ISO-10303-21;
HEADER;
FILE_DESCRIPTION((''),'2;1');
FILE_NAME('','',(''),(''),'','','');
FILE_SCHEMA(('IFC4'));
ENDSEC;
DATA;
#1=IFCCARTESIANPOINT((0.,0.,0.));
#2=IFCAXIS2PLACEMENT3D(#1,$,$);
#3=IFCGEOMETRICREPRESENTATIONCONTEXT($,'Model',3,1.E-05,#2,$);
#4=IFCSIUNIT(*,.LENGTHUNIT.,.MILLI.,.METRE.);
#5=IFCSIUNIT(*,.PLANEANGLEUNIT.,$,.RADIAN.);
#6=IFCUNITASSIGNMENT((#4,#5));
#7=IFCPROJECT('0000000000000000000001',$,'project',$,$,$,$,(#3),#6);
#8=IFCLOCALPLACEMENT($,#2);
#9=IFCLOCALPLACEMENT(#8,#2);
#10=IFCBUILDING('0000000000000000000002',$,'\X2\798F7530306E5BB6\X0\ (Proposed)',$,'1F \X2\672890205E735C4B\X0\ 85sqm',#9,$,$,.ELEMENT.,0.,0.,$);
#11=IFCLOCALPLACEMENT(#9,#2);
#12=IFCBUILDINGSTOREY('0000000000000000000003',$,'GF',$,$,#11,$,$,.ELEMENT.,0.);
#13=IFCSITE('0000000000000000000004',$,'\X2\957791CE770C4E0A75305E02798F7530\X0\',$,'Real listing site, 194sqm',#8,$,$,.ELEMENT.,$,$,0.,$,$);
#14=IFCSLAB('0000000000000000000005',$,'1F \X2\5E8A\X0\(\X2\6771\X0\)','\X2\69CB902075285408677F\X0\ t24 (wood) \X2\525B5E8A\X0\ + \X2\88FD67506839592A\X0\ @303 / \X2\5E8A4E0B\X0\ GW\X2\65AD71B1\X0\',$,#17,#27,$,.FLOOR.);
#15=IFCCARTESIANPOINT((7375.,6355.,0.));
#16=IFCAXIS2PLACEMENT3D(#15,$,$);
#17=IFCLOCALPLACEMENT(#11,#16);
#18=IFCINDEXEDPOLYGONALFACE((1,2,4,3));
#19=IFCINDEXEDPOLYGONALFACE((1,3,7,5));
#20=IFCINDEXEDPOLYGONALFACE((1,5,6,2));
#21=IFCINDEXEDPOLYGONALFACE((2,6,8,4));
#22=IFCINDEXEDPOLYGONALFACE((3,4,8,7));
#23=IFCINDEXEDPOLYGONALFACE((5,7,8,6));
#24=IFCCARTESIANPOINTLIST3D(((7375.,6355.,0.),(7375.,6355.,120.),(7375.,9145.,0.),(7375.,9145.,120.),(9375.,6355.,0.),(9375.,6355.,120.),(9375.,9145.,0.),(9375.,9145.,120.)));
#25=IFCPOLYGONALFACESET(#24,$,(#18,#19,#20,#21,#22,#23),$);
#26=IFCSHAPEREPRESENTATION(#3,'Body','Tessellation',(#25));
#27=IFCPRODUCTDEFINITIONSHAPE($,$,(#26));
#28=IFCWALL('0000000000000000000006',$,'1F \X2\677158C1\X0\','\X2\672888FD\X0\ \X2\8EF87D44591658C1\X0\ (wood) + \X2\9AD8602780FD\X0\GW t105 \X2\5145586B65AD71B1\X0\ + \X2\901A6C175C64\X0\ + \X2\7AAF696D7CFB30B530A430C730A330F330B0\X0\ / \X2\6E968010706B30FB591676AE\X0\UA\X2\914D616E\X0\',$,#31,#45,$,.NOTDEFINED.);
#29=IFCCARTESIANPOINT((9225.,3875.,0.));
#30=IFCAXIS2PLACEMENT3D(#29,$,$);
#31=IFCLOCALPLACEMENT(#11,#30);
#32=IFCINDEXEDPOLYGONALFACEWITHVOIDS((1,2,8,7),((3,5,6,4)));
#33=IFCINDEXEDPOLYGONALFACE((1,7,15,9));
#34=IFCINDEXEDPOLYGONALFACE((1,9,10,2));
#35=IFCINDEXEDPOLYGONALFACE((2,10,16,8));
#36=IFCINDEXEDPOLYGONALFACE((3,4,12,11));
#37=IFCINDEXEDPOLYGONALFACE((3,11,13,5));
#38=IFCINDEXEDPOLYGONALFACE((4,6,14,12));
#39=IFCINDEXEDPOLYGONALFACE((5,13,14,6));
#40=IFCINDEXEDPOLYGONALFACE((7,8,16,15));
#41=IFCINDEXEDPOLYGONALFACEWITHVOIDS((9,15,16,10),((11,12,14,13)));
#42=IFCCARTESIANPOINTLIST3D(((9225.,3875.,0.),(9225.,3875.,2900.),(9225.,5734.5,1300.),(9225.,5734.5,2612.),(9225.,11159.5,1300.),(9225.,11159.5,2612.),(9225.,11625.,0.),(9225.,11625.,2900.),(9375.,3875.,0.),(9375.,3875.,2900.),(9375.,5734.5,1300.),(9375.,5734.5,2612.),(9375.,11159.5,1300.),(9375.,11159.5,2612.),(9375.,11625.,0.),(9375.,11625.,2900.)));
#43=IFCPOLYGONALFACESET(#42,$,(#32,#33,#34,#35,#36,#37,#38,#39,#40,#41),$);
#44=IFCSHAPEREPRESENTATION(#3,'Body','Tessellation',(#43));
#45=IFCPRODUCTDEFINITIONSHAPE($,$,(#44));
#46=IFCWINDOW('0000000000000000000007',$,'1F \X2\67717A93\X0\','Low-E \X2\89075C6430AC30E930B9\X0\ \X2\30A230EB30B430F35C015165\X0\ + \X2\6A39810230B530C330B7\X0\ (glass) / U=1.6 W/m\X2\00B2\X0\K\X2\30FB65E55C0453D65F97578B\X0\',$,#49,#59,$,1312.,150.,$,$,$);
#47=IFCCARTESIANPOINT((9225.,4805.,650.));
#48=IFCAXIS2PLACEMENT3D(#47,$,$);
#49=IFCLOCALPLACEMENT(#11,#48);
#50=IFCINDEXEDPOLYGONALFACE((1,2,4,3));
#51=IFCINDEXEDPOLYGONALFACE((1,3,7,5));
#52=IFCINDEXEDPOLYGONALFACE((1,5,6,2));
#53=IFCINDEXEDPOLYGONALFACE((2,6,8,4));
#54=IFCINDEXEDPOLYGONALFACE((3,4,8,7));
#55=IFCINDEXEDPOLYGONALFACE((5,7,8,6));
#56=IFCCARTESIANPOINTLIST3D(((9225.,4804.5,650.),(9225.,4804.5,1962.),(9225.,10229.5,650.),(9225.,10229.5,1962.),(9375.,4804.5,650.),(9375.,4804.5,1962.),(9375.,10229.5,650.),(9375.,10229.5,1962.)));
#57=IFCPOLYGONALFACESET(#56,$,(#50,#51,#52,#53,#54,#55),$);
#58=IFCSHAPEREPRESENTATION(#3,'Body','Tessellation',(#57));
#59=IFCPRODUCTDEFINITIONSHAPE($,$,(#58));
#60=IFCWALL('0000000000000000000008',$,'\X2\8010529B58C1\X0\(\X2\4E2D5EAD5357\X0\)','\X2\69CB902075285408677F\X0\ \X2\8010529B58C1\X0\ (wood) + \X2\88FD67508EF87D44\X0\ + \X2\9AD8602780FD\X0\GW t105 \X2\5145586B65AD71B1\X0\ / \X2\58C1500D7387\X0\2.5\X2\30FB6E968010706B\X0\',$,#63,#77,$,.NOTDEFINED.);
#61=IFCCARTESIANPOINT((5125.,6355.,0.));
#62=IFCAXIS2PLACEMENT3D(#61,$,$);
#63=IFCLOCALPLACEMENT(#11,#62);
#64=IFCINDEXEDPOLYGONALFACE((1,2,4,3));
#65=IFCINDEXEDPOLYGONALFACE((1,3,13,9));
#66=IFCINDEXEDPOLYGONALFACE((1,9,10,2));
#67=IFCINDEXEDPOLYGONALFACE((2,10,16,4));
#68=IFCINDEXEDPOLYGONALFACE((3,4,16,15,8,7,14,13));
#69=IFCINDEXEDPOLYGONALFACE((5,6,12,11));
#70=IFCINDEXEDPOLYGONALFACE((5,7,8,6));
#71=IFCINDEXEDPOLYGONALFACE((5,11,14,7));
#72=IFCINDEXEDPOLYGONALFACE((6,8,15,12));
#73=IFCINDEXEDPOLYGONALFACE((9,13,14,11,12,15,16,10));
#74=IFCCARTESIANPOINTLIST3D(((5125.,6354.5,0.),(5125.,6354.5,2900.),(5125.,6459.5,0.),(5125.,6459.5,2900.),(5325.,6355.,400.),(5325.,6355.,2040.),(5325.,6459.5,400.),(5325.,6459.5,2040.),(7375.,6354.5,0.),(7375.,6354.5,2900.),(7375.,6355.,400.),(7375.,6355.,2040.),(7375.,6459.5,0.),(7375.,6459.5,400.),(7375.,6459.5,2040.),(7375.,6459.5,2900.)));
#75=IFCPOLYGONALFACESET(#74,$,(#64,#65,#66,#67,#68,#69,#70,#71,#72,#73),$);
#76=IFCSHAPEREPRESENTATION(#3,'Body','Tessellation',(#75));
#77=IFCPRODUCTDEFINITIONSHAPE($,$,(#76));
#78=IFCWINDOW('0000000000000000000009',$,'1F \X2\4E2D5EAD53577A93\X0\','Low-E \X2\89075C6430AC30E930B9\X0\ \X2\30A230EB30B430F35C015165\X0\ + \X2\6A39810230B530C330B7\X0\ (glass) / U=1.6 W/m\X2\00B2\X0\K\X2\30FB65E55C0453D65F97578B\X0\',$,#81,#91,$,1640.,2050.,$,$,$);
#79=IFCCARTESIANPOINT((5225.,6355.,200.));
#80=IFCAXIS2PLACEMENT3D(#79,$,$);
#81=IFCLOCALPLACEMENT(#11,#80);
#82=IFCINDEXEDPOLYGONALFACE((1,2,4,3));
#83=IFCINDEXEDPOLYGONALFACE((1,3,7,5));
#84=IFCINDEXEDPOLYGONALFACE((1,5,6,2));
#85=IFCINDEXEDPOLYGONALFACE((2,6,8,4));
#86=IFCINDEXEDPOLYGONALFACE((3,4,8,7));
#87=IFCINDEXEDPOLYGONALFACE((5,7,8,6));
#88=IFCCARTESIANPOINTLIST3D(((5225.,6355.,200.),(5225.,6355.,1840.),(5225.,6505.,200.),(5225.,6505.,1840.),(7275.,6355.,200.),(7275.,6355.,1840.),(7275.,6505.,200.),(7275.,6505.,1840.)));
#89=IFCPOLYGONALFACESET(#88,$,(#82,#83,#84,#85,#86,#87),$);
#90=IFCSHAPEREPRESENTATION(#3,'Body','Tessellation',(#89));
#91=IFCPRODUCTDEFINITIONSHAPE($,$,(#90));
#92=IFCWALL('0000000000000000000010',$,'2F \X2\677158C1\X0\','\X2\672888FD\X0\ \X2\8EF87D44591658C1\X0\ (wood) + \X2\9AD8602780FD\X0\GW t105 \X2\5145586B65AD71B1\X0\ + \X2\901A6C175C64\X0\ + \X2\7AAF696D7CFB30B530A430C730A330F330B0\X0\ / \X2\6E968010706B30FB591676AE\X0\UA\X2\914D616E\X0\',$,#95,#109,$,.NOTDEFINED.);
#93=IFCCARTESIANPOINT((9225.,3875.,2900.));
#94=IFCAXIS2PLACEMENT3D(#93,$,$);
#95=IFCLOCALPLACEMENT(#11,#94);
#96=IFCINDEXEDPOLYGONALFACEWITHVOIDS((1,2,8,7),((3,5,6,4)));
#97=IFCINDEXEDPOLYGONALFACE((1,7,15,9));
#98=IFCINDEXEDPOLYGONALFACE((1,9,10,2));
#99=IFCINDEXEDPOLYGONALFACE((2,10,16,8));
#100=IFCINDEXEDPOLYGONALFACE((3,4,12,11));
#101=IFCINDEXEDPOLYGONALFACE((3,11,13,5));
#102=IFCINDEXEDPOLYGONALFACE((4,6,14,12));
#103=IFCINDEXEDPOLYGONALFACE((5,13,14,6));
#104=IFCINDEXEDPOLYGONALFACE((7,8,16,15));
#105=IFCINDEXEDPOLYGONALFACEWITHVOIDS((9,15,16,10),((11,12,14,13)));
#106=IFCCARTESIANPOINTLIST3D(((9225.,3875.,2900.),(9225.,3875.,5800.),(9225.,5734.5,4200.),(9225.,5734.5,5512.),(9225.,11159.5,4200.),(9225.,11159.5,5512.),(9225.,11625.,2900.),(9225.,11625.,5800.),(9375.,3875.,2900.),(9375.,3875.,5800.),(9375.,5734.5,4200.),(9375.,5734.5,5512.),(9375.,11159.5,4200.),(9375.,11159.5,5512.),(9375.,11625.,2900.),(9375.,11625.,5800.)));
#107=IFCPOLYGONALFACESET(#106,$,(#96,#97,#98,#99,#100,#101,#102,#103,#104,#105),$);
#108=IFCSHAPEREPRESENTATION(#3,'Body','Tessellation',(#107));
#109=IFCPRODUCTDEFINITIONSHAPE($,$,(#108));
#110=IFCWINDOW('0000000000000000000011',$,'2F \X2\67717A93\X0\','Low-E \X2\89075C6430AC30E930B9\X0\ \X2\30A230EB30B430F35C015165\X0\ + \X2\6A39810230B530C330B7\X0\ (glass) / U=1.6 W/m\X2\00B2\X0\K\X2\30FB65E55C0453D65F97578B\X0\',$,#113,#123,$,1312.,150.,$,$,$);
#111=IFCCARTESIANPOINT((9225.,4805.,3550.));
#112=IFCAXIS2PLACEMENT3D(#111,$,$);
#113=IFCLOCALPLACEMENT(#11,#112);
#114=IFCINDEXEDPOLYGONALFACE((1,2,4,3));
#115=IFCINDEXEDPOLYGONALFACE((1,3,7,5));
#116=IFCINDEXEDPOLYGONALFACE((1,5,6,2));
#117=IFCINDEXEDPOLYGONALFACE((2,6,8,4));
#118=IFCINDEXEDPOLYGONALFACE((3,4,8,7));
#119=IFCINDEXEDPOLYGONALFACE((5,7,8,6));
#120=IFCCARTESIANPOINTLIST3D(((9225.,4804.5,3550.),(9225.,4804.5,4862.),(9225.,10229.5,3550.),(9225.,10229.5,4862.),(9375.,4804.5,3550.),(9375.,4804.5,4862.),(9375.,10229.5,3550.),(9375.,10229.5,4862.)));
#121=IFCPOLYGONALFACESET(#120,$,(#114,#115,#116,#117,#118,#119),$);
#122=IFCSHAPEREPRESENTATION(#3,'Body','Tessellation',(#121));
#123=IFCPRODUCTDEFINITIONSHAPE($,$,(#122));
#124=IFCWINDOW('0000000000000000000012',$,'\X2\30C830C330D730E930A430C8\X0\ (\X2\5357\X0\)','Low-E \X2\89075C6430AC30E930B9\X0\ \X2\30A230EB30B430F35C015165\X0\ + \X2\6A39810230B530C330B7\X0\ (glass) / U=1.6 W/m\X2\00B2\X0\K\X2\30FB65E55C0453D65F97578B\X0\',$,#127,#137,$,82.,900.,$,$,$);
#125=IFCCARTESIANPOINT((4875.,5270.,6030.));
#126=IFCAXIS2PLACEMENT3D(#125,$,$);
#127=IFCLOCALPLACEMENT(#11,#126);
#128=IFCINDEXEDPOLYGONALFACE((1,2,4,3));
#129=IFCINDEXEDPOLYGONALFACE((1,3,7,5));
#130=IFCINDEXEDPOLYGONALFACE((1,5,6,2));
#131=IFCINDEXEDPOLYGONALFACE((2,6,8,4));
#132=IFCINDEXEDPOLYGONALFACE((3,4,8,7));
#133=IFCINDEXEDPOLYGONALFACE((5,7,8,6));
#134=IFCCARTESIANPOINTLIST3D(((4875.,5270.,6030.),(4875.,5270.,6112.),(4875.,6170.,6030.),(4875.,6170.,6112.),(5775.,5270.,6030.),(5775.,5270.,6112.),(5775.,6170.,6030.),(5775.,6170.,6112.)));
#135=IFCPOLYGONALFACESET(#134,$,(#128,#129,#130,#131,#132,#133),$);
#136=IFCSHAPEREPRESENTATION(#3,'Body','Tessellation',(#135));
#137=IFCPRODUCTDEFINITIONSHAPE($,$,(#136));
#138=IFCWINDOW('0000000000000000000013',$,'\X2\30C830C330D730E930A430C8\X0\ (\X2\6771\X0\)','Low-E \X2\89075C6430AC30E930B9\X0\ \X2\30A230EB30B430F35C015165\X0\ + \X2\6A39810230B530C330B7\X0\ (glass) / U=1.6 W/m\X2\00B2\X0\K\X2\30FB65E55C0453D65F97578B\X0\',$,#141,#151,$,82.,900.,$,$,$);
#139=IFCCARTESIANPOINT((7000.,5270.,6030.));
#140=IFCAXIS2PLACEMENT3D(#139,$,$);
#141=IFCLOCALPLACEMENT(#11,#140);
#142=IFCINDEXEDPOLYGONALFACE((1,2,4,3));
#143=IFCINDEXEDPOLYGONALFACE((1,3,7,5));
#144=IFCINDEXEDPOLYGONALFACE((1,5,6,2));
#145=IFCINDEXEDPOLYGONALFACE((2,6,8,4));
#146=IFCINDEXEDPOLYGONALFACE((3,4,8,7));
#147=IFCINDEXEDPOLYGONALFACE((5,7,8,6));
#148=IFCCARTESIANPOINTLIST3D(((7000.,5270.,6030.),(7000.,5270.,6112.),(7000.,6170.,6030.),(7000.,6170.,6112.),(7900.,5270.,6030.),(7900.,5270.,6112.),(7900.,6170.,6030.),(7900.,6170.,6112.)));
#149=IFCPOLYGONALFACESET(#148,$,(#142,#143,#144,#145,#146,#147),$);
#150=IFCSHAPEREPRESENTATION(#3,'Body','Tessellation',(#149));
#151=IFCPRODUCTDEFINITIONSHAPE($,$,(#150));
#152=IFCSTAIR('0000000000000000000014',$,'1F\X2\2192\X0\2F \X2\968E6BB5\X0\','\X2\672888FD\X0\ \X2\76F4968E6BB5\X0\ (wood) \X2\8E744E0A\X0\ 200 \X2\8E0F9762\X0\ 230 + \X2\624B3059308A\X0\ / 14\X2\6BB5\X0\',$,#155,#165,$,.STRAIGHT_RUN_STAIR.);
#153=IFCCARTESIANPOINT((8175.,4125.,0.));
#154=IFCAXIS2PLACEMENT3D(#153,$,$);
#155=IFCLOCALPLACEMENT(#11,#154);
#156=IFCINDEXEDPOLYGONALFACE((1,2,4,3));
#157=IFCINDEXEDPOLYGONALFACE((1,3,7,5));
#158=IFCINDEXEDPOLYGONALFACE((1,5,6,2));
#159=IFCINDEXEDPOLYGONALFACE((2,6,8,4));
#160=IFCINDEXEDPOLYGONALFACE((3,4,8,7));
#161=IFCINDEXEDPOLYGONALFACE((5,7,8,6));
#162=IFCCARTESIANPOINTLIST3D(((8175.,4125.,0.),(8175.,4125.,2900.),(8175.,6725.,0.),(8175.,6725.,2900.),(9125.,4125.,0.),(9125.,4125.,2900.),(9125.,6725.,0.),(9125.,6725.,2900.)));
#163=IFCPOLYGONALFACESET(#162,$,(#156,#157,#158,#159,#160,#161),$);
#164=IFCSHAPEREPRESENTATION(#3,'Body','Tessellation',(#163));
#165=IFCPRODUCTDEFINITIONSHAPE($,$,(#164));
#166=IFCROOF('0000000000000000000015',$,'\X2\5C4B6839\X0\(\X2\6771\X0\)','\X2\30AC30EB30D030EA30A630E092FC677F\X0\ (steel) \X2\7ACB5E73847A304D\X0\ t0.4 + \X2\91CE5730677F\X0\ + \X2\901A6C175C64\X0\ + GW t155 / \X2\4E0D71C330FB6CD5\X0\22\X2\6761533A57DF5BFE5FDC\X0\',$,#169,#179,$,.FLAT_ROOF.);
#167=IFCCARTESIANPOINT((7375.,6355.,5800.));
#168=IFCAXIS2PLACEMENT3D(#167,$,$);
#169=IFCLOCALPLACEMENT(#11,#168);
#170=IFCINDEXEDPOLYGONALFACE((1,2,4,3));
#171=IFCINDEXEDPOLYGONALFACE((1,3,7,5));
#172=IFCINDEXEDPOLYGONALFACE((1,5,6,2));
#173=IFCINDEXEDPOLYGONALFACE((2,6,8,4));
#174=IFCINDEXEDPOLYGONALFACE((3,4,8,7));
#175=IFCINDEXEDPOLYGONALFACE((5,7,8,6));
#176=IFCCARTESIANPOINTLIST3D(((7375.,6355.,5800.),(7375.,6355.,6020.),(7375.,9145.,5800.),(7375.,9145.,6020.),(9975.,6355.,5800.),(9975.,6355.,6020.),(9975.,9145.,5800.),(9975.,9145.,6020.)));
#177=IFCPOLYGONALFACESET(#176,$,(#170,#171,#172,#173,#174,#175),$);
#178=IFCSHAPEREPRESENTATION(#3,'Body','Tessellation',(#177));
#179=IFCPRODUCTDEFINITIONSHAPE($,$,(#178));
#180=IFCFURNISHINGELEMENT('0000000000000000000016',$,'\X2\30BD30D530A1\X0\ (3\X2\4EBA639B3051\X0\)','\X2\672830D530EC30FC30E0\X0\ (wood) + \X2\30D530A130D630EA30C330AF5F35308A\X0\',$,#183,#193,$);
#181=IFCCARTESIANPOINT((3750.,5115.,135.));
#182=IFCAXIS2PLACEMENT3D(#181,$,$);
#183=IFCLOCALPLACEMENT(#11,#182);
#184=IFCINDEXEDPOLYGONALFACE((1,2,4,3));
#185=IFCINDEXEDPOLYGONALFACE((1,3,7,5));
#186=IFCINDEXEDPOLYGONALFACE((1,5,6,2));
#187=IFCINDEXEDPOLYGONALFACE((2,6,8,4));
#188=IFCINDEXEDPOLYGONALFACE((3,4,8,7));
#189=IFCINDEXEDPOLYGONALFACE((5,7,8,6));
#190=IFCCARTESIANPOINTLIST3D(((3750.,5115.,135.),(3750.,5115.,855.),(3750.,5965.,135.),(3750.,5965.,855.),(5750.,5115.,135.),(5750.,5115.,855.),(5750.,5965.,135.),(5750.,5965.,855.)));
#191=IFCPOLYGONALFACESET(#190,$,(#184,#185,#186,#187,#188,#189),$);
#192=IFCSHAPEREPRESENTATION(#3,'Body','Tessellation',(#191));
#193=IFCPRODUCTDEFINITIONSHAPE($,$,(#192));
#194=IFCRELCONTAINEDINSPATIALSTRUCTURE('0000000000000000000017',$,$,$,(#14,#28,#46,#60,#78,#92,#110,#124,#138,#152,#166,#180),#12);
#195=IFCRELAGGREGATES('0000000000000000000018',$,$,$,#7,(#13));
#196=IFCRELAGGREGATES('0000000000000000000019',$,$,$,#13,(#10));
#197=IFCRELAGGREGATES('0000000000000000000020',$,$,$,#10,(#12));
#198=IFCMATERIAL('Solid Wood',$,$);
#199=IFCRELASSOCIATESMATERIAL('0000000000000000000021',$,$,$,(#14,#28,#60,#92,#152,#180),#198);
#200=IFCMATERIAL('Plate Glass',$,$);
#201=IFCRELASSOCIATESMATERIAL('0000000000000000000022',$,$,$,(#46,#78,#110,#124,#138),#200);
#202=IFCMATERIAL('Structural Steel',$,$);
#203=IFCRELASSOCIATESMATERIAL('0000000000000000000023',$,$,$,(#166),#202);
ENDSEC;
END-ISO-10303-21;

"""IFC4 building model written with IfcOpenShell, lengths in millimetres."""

from ifc_helpers import new_model, si_unit, frame, frame_2d, origin, place, context, project, spatial, rectangle, extrude, material, element, fill, save


model = new_model("IFC4")

# Units and contexts
model_context = context("Model", 3, precision=1e-05, world=origin())
ifc_project = project(units=[si_unit("LENGTHUNIT", "METRE", prefix="MILLI"), si_unit("PLANEANGLEUNIT", "RADIAN")], contexts=[model_context])

# Site, building, storey
site_placement = place(None, origin())
site = spatial("IfcSite", under=ifc_project, at=site_placement, Name="長野県上田市福田", ObjectType="Real listing site, 194sqm", CompositionType="ELEMENT", RefElevation=0.0)
building_placement = place(site_placement, origin())
building = spatial("IfcBuilding", under=site, at=building_placement, Name="福田の家 (Proposed)", ObjectType="1F 木造平屋 85sqm", CompositionType="ELEMENT", ElevationOfRefHeight=0.0, ElevationOfTerrain=0.0)
storey_placement = place(building_placement, origin())
storey = spatial("IfcBuildingStorey", under=building, at=storey_placement, Name="GF", CompositionType="ELEMENT", Elevation=0.0)

# Slab
ifc_material_1 = material(Name="Solid Wood")
slab_placement = place(storey_placement, frame((7375.0, 6355.0, 0.0)))
element("IfcSlab", 1, at=slab_placement, inside=storey, material=ifc_material_1, Name="1F 床(東)", Description="構造用合板 t24 (wood) 剛床 + 製材根太 @303 / 床下 GW断熱", PredefinedType="FLOOR", context=model_context, shape_type="SweptSolid", body=[
    extrude(rectangle(XDim=2000.0, YDim=2790.0, at=frame_2d((1000.0, 1395.0))), frame((7375.0, 6355.0, 0.0)), (0.0, 0.0, 1.0), 120.0),
])

# Walls, openings, windows
wall_1_placement = place(storey_placement, frame((9225.0, 3875.0, 0.0)))
wall_1 = element("IfcWall", 2, at=wall_1_placement, inside=storey, material=ifc_material_1, Name="1F 東壁", Description="木製 軸組外壁 (wood) + 高性能GW t105 充填断熱 + 通気層 + 窯業系サイディング / 準耐火・外皮UA配慮", PredefinedType="NOTDEFINED", context=model_context, shape_type="SweptSolid", body=[
    extrude(rectangle(XDim=150.0, YDim=7750.0, at=frame_2d((75.0, 3875.0))), frame((9225.0, 3875.0, 0.0)), (0.0, 0.0, 1.0), 2900.0),
])
opening_1_placement = place(storey_placement, frame((9225.0, 4805.0, 650.0)))
opening_1 = element("IfcOpeningElement", 3, at=opening_1_placement, cuts=wall_1, PredefinedType="NOTDEFINED", context=model_context, shape_type="SweptSolid", body=[
    extrude(rectangle(XDim=150.0, YDim=5425.0, at=frame_2d((75.0, 2712.0))), frame((9225.0, 4805.0, 650.0)), (0.0, 0.0, 1.0), 1312.0),
])
ifc_material_2 = material(Name="Plate Glass")
window_1_placement = place(storey_placement, frame((9225.0, 4805.0, 650.0)))
window_1 = element("IfcWindow", 4, at=window_1_placement, inside=storey, material=ifc_material_2, Name="1F 東窓", Description="Low-E 複層ガラス アルゴン封入 + 樹脂サッシ (glass) / U=1.6 W/m²K・日射取得型", OverallHeight=1312.0, OverallWidth=150.0, context=model_context, shape_type="SweptSolid", body=[
    extrude(rectangle(XDim=150.0, YDim=5425.0, at=frame_2d((75.0, 2712.0))), frame((9225.0, 4805.0, 650.0)), (0.0, 0.0, 1.0), 1312.0),
])
fill(opening_1, window_1)
wall_2_placement = place(storey_placement, frame((5125.0, 6355.0, 0.0)))
wall_2 = element("IfcWall", 5, at=wall_2_placement, inside=storey, material=ifc_material_1, Name="耐力壁(中庭南)", Description="構造用合板 耐力壁 (wood) + 製材軸組 + 高性能GW t105 充填断熱 / 壁倍率2.5・準耐火", PredefinedType="NOTDEFINED", context=model_context, shape_type="SweptSolid", body=[
    extrude(rectangle(XDim=2250.0, YDim=105.0, at=frame_2d((1125.0, 52.0))), frame((5125.0, 6355.0, 0.0)), (0.0, 0.0, 1.0), 2900.0),
])
opening_2_placement = place(storey_placement, frame((5225.0, 6355.0, 200.0)))
opening_2 = element("IfcOpeningElement", 6, at=opening_2_placement, cuts=wall_2, PredefinedType="NOTDEFINED", context=model_context, shape_type="SweptSolid", body=[
    extrude(rectangle(XDim=2050.0, YDim=150.0, at=frame_2d((1025.0, 75.0))), frame((5225.0, 6355.0, 200.0)), (0.0, 0.0, 1.0), 1640.0),
])
window_2_placement = place(storey_placement, frame((5225.0, 6355.0, 200.0)))
window_2 = element("IfcWindow", 7, at=window_2_placement, inside=storey, material=ifc_material_2, Name="1F 中庭南窓", Description="Low-E 複層ガラス アルゴン封入 + 樹脂サッシ (glass) / U=1.6 W/m²K・日射取得型", OverallHeight=1640.0, OverallWidth=2050.0, context=model_context, shape_type="SweptSolid", body=[
    extrude(rectangle(XDim=2050.0, YDim=150.0, at=frame_2d((1025.0, 75.0))), frame((5225.0, 6355.0, 200.0)), (0.0, 0.0, 1.0), 1640.0),
])
fill(opening_2, window_2)

# Wall, opening, window
wall_3_placement = place(storey_placement, frame((9225.0, 3875.0, 2900.0)))
wall_3 = element("IfcWall", 8, at=wall_3_placement, inside=storey, material=ifc_material_1, Name="2F 東壁", Description="木製 軸組外壁 (wood) + 高性能GW t105 充填断熱 + 通気層 + 窯業系サイディング / 準耐火・外皮UA配慮", PredefinedType="NOTDEFINED", context=model_context, shape_type="SweptSolid", body=[
    extrude(rectangle(XDim=150.0, YDim=7750.0, at=frame_2d((75.0, 3875.0))), frame((9225.0, 3875.0, 2900.0)), (0.0, 0.0, 1.0), 2900.0),
])
opening_3_placement = place(storey_placement, frame((9225.0, 4805.0, 3550.0)))
opening_3 = element("IfcOpeningElement", 9, at=opening_3_placement, cuts=wall_3, PredefinedType="NOTDEFINED", context=model_context, shape_type="SweptSolid", body=[
    extrude(rectangle(XDim=150.0, YDim=5425.0, at=frame_2d((75.0, 2712.0))), frame((9225.0, 4805.0, 3550.0)), (0.0, 0.0, 1.0), 1312.0),
])
window_3_placement = place(storey_placement, frame((9225.0, 4805.0, 3550.0)))
window_3 = element("IfcWindow", 10, at=window_3_placement, inside=storey, material=ifc_material_2, Name="2F 東窓", Description="Low-E 複層ガラス アルゴン封入 + 樹脂サッシ (glass) / U=1.6 W/m²K・日射取得型", OverallHeight=1312.0, OverallWidth=150.0, context=model_context, shape_type="SweptSolid", body=[
    extrude(rectangle(XDim=150.0, YDim=5425.0, at=frame_2d((75.0, 2712.0))), frame((9225.0, 4805.0, 3550.0)), (0.0, 0.0, 1.0), 1312.0),
])
fill(opening_3, window_3)

# Windows
window_4_placement = place(storey_placement, frame((4875.0, 5270.0, 6030.0)))
element("IfcWindow", 11, at=window_4_placement, inside=storey, material=ifc_material_2, Name="トップライト (南)", Description="Low-E 複層ガラス アルゴン封入 + 樹脂サッシ (glass) / U=1.6 W/m²K・日射取得型", OverallHeight=82.0, OverallWidth=900.0, context=model_context, shape_type="SweptSolid", body=[
    extrude(rectangle(XDim=900.0, YDim=900.0, at=frame_2d((450.0, 450.0))), frame((4875.0, 5270.0, 6030.0)), (0.0, 0.0, 1.0), 82.0),
])
window_5_placement = place(storey_placement, frame((7000.0, 5270.0, 6030.0)))
element("IfcWindow", 12, at=window_5_placement, inside=storey, material=ifc_material_2, Name="トップライト (東)", Description="Low-E 複層ガラス アルゴン封入 + 樹脂サッシ (glass) / U=1.6 W/m²K・日射取得型", OverallHeight=82.0, OverallWidth=900.0, context=model_context, shape_type="SweptSolid", body=[
    extrude(rectangle(XDim=900.0, YDim=900.0, at=frame_2d((450.0, 450.0))), frame((7000.0, 5270.0, 6030.0)), (0.0, 0.0, 1.0), 82.0),
])

# Stair
stair_placement = place(storey_placement, frame((8175.0, 4125.0, 0.0)))
element("IfcStair", 13, at=stair_placement, inside=storey, material=ifc_material_1, Name="1F→2F 階段", Description="木製 直階段 (wood) 蹴上 200 踏面 230 + 手すり / 14段", PredefinedType="STRAIGHT_RUN_STAIR", context=model_context, shape_type="SweptSolid", body=[
    extrude(rectangle(XDim=950.0, YDim=2600.0, at=frame_2d((475.0, 1300.0))), frame((8175.0, 4125.0, 0.0)), (0.0, 0.0, 1.0), 2900.0),
])

# Roof
ifc_material_3 = material(Name="Structural Steel")
roof_placement = place(storey_placement, frame((7375.0, 6355.0, 5800.0)))
element("IfcRoof", 14, at=roof_placement, inside=storey, material=ifc_material_3, Name="屋根(東)", Description="ガルバリウム鋼板 (steel) 立平葺き t0.4 + 野地板 + 通気層 + GW t155 / 不燃・法22条区域対応", PredefinedType="FLAT_ROOF", context=model_context, shape_type="SweptSolid", body=[
    extrude(rectangle(XDim=2600.0, YDim=2790.0, at=frame_2d((1300.0, 1395.0))), frame((7375.0, 6355.0, 5800.0)), (0.0, 0.0, 1.0), 220.0),
])

# Furnishing element
furnishing_1_placement = place(storey_placement, frame((3750.0, 5115.0, 135.0)))
element("IfcFurnishingElement", 15, at=furnishing_1_placement, inside=storey, material=ifc_material_1, Name="ソファ (3人掛け)", Description="木フレーム (wood) + ファブリック張り", context=model_context, shape_type="SweptSolid", body=[
    extrude(rectangle(XDim=2000.0, YDim=850.0, at=frame_2d((1000.0, 425.0))), frame((3750.0, 5115.0, 135.0)), (0.0, 0.0, 1.0), 720.0),
])

save(model, "model.ifc")
